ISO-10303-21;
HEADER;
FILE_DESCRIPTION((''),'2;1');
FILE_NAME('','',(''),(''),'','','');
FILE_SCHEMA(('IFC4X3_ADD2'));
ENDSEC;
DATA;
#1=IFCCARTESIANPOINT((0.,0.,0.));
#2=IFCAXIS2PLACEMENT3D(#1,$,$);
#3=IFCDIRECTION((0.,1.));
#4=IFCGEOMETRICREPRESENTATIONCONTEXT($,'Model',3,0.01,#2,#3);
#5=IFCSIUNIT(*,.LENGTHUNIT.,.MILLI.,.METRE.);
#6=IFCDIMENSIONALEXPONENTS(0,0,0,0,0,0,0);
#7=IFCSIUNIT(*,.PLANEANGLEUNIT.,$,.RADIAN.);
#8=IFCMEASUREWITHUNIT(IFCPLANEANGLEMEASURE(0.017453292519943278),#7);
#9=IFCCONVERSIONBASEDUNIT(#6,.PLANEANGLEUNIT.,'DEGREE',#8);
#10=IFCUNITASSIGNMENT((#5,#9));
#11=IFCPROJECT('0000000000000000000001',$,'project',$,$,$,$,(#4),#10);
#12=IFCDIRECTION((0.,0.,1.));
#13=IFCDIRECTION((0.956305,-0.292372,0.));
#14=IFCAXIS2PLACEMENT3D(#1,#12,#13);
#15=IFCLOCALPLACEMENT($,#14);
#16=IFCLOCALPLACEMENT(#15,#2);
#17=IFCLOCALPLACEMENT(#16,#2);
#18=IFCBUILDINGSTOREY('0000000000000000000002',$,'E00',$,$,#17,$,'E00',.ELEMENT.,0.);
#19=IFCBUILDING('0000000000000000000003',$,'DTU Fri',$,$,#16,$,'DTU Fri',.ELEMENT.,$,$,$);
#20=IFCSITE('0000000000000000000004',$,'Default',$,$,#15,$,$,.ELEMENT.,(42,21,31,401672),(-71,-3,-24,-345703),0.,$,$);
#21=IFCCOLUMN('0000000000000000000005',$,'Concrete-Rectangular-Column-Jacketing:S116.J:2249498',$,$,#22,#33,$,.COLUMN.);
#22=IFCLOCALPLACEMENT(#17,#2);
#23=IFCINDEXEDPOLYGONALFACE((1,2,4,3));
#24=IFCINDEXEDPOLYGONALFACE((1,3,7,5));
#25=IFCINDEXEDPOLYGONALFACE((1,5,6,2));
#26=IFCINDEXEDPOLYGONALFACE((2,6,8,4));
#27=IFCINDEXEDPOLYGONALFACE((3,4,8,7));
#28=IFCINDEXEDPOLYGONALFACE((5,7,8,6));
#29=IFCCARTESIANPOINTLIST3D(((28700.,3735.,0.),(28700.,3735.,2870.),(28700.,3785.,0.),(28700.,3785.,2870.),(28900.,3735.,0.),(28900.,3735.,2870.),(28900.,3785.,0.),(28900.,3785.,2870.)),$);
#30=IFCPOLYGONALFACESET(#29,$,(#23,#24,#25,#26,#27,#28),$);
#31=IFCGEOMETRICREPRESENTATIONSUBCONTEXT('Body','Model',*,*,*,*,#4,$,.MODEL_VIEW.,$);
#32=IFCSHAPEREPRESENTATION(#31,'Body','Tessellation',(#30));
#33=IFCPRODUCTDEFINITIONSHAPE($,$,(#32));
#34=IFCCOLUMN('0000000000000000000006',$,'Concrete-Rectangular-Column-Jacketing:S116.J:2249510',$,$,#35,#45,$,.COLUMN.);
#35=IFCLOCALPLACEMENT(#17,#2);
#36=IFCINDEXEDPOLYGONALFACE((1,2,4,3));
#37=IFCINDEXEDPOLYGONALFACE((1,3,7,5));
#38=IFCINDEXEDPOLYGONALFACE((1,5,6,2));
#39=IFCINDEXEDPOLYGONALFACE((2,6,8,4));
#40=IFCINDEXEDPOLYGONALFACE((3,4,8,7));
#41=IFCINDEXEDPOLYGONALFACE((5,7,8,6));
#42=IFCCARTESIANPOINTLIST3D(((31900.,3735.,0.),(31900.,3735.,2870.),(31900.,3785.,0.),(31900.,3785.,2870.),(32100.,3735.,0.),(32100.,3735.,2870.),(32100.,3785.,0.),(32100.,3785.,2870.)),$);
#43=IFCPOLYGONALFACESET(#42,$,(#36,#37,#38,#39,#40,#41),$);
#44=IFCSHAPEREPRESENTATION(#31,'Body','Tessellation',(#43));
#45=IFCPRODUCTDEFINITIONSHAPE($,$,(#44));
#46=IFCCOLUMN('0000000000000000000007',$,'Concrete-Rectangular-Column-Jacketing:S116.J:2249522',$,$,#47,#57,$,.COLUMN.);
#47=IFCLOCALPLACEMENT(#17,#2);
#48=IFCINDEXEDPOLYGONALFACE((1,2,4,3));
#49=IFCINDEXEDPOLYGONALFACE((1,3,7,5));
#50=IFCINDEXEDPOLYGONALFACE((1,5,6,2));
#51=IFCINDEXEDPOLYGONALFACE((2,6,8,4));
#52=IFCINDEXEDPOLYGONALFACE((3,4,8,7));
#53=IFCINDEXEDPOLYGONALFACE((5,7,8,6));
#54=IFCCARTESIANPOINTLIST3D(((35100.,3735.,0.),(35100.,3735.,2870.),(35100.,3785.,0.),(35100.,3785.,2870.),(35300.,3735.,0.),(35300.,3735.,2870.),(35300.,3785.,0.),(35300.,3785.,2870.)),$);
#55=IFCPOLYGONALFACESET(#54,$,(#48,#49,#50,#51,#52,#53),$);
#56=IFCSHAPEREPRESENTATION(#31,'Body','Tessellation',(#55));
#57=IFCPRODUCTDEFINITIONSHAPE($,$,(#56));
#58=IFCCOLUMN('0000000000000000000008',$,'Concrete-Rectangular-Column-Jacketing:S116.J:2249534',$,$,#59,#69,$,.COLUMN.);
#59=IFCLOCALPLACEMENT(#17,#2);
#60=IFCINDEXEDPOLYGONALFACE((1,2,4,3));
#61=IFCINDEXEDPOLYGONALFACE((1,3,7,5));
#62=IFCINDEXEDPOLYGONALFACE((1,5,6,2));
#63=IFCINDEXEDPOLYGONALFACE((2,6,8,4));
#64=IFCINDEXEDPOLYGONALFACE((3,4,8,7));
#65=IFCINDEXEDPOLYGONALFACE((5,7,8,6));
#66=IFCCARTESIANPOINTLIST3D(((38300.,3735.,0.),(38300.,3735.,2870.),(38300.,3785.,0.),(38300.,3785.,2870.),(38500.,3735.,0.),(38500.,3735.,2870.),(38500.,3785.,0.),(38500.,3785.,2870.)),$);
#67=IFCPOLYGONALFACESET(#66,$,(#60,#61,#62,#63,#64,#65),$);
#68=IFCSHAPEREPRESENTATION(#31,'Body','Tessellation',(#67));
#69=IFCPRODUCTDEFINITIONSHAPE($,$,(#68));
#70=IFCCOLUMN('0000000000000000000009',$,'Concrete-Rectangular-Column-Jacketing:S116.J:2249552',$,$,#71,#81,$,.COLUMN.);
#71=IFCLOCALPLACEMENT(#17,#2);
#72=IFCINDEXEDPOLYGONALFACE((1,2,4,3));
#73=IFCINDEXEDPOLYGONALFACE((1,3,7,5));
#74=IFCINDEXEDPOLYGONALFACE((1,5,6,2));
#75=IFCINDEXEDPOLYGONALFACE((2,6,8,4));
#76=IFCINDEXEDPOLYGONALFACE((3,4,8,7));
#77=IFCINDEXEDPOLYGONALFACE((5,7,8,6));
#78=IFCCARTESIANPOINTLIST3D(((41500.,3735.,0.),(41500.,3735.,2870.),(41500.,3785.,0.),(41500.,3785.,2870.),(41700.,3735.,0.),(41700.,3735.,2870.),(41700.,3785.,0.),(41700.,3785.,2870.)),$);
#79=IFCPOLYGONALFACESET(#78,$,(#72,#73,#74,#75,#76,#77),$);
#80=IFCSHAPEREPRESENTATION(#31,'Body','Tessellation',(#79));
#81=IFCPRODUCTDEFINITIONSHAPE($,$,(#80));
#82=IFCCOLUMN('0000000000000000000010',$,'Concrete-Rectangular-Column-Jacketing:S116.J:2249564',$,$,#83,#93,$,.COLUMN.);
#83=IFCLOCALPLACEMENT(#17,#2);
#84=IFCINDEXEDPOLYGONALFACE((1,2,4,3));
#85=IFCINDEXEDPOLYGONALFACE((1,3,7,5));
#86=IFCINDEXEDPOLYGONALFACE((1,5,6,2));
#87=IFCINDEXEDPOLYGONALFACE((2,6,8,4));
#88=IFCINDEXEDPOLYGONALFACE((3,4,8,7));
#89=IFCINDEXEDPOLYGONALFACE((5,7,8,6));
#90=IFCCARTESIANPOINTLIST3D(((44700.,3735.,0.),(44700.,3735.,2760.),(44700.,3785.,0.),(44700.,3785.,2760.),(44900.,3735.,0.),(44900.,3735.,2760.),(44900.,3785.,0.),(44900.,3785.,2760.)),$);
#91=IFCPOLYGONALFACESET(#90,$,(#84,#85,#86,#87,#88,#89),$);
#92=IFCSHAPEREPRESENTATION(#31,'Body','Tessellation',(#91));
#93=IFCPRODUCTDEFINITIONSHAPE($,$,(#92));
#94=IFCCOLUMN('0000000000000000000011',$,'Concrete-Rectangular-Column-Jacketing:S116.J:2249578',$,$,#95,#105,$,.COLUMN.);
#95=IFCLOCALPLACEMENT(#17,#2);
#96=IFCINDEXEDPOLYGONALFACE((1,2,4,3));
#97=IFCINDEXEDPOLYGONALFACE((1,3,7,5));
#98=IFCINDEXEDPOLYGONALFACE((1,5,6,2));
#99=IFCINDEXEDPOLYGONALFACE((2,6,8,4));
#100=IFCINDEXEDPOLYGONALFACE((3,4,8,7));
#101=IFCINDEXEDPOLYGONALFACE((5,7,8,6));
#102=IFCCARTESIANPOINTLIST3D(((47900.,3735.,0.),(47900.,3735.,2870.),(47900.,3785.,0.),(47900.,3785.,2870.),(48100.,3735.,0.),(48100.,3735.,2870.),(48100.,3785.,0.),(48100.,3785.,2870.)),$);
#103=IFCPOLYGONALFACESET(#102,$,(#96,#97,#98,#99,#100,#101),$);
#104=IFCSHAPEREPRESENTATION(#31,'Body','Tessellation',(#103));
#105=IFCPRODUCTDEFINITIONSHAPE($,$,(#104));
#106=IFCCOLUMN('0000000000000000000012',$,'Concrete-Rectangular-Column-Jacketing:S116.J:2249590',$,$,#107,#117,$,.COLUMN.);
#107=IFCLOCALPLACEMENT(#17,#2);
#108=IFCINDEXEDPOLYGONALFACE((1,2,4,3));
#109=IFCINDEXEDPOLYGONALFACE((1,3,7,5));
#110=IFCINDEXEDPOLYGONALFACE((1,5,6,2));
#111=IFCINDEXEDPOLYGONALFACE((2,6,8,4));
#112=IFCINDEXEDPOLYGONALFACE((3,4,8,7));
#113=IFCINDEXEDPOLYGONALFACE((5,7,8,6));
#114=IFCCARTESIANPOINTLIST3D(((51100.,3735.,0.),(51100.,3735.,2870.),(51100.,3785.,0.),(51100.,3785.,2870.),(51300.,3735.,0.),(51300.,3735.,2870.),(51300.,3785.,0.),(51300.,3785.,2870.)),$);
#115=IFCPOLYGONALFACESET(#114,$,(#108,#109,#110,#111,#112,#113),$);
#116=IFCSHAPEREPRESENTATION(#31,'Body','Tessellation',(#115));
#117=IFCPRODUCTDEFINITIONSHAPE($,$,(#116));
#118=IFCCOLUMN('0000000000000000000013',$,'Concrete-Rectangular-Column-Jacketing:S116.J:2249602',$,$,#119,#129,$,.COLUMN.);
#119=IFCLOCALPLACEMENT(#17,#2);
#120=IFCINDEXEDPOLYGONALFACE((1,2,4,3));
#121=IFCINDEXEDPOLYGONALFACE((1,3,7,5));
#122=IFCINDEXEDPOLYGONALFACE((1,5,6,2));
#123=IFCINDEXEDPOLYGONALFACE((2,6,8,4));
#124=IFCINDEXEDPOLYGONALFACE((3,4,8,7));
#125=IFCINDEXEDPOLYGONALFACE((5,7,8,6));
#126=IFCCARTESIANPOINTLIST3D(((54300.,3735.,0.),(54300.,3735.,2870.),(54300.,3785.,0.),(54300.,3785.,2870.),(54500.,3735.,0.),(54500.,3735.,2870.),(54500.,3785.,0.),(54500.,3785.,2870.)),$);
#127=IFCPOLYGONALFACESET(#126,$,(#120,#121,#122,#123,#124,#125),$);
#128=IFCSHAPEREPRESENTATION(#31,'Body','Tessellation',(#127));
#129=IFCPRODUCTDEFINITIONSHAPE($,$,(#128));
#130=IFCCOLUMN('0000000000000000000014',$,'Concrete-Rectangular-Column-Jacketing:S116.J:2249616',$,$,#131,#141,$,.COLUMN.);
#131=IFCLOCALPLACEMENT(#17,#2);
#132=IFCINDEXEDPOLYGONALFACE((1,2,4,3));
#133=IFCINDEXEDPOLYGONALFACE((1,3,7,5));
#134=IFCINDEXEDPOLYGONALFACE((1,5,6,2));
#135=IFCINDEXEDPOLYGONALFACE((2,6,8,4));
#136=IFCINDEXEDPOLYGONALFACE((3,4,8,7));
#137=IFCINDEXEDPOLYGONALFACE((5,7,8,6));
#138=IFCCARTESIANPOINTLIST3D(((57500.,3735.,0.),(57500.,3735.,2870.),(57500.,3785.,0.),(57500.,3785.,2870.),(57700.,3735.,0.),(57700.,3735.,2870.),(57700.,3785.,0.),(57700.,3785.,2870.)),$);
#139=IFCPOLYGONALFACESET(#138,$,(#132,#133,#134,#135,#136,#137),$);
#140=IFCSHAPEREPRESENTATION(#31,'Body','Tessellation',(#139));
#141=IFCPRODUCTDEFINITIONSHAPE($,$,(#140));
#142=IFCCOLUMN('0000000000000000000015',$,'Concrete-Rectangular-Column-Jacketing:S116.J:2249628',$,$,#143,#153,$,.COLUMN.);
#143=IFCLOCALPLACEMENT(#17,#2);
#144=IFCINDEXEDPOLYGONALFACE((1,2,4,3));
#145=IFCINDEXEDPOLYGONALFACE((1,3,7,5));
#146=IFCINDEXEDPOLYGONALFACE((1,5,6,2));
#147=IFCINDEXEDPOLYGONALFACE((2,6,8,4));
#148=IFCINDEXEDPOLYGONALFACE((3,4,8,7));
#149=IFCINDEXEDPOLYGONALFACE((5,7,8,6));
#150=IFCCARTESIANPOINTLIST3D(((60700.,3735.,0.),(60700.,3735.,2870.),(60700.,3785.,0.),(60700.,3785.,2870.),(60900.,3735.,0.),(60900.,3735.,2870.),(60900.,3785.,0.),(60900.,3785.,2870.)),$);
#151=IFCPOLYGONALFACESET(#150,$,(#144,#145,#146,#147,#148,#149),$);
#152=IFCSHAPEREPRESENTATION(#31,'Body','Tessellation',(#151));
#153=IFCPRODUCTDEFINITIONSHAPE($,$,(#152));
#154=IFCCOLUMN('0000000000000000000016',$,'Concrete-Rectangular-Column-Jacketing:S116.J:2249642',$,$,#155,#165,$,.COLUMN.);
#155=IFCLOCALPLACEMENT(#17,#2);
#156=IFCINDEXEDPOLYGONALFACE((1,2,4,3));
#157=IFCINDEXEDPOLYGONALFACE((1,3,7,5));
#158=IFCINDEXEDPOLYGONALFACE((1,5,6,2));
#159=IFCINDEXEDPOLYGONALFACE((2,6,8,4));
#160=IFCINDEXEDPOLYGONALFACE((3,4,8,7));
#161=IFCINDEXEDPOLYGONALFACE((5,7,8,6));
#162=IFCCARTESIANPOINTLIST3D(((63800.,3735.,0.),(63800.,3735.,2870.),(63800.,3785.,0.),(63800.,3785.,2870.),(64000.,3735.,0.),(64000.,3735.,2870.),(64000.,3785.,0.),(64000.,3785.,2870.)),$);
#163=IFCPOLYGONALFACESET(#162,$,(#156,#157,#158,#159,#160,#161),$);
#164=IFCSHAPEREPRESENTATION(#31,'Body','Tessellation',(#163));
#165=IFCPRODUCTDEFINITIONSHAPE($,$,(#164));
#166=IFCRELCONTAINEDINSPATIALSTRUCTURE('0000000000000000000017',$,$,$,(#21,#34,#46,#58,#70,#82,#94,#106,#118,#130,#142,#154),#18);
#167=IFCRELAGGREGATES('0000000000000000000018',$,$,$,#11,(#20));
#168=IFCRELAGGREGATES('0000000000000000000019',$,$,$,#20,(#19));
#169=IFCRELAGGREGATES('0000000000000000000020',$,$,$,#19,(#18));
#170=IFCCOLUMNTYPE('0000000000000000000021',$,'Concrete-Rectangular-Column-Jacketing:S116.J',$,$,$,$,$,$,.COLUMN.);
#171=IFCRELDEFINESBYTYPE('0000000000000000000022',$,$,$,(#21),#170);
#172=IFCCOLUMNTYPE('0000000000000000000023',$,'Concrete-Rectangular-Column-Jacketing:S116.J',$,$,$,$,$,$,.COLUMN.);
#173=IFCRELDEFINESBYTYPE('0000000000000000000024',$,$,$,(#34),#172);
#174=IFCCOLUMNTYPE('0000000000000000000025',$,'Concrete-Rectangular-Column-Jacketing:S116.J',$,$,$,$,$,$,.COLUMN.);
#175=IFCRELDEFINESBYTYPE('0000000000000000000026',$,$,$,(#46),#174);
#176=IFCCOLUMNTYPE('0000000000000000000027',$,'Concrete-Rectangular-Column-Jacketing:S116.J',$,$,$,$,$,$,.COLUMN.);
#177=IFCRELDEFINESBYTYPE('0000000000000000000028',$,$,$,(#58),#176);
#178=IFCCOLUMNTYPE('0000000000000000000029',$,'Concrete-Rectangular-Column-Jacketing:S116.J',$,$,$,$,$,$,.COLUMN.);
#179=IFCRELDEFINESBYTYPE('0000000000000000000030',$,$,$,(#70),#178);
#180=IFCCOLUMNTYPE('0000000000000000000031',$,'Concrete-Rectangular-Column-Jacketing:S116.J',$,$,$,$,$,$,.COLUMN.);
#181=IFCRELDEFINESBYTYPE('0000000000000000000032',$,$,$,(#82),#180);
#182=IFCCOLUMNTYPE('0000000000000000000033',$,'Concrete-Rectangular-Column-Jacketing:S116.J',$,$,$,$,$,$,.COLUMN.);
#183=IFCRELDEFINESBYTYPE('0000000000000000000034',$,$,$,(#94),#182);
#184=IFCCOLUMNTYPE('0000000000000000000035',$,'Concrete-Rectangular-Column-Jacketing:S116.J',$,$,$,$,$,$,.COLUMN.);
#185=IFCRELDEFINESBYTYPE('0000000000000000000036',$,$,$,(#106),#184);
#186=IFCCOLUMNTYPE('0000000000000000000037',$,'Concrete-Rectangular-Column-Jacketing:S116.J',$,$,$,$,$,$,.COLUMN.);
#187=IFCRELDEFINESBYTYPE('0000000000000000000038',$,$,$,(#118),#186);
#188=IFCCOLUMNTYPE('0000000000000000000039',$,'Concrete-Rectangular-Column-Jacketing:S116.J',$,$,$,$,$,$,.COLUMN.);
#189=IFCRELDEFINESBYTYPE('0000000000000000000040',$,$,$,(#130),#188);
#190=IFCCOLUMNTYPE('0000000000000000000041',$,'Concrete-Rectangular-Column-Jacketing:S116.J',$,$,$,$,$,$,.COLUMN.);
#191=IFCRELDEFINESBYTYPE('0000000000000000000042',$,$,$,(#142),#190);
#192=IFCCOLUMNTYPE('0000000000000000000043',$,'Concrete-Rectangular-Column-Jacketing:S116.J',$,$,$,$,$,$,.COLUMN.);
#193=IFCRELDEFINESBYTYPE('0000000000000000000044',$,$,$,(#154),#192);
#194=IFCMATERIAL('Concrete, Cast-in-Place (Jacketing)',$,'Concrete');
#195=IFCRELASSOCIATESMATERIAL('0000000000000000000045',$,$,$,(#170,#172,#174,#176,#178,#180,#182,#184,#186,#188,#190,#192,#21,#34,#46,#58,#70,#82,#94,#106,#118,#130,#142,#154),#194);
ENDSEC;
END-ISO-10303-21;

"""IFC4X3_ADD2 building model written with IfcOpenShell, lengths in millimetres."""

from ifc_helpers import new_model, entity, si_unit, converted_unit, direction, frame, frame_2d, origin, place, context, subcontext, project, spatial, rectangle, extrude, source, transform, mapped, material, material_profile, profile_set, profile_usage, type_object, type_shapes, element, save


model = new_model("IFC4X3_ADD2")

# Units and contexts
model_context = context("Model", 3, precision=0.01, world=origin(), true_north=direction((0.0, 1.0)))
body_context = subcontext(model_context, "Body", "Model", "MODEL_VIEW")
ifc_project = project(units=[si_unit("LENGTHUNIT", "METRE", prefix="MILLI"), converted_unit("PLANEANGLEUNIT", "DEGREE", entity("IfcPlaneAngleMeasure", 0.017453292519943278), si_unit("PLANEANGLEUNIT", "RADIAN"), dimensions=[0, 0, 0, 0, 0, 0, 0])], contexts=[model_context])

# Site, building, storey
site_placement = place(None, frame((0.0, 0.0, 0.0), z_axis=(0.0, 0.0, 1.0), x_axis=(0.956305, -0.292372, 0.0)))
site = spatial("IfcSite", under=ifc_project, at=site_placement, Name="Default", CompositionType="ELEMENT", RefLatitude=(42, 21, 31, 401672), RefLongitude=(-71, -3, -24, -345703), RefElevation=0.0)
building_placement = place(site_placement, origin())
building = spatial("IfcBuilding", under=site, at=building_placement, Name="DTU Fri", LongName="DTU Fri", CompositionType="ELEMENT")
storey_placement = place(building_placement, origin())
storey = spatial("IfcBuildingStorey", under=building, at=storey_placement, Name="E00", LongName="E00", CompositionType="ELEMENT", Elevation=0.0)

# Columns
ifc_material_1 = material(Name="Concrete, Cast-in-Place (Jacketing)", Category="Concrete")
ifc_material_profile = material_profile(ifc_material_1, rectangle(XDim=50.0, YDim=200.0, at=frame_2d((0.0, 0.0), x_axis=(1.0, 0.0))), Name="S116.J")
ifc_profile_set = profile_set([ifc_material_profile], Name="S116.J")
ifc_profile_usage = profile_usage(ifc_profile_set)
column_type_1 = type_object("IfcColumnType", Name="Concrete-Rectangular-Column-Jacketing:S116.J", PredefinedType="COLUMN", material=ifc_profile_set)
shared_shape_1 = source(origin(), body_context, "Body", "SweptSolid", [
    extrude(rectangle(XDim=50.0, YDim=200.0, at=frame_2d((0.0, 0.0), x_axis=(1.0, 0.0))), frame((28800.0, 3760.0, 0.0), z_axis=(0.0, 0.0, 1.0), x_axis=(0.0, -1.0, 0.0)), (0.0, 0.0, 1.0), 2870.0),
])
type_shapes(column_type_1, [shared_shape_1])
column_1_placement = place(storey_placement, origin())
element("IfcColumn", 1, at=column_1_placement, inside=storey, type_object=column_type_1, material=ifc_profile_usage, Name="Concrete-Rectangular-Column-Jacketing:S116.J:2249498", PredefinedType="COLUMN", context=body_context, shape_type="MappedRepresentation", body=[
    mapped(shared_shape_1, transform((0.0, 0.0, 0.0), scale=1.0)),
])
column_type_2 = type_object("IfcColumnType", Name="Concrete-Rectangular-Column-Jacketing:S116.J", PredefinedType="COLUMN", material=ifc_profile_set)
shared_shape_2 = source(origin(), body_context, "Body", "SweptSolid", [
    extrude(rectangle(XDim=50.0, YDim=200.0, at=frame_2d((0.0, 0.0), x_axis=(1.0, 0.0))), frame((32000.0, 3760.0, 0.0), z_axis=(0.0, 0.0, 1.0), x_axis=(0.0, -1.0, 0.0)), (0.0, 0.0, 1.0), 2870.0),
])
type_shapes(column_type_2, [shared_shape_2])
column_2_placement = place(storey_placement, origin())
element("IfcColumn", 2, at=column_2_placement, inside=storey, type_object=column_type_2, material=ifc_profile_usage, Name="Concrete-Rectangular-Column-Jacketing:S116.J:2249510", PredefinedType="COLUMN", context=body_context, shape_type="MappedRepresentation", body=[
    mapped(shared_shape_2, transform((0.0, 0.0, 0.0), scale=1.0)),
])
column_type_3 = type_object("IfcColumnType", Name="Concrete-Rectangular-Column-Jacketing:S116.J", PredefinedType="COLUMN", material=ifc_profile_set)
shared_shape_3 = source(origin(), body_context, "Body", "SweptSolid", [
    extrude(rectangle(XDim=50.0, YDim=200.0, at=frame_2d((0.0, 0.0), x_axis=(1.0, 0.0))), frame((35200.0, 3760.0, 0.0), z_axis=(0.0, 0.0, 1.0), x_axis=(0.0, -1.0, 0.0)), (0.0, 0.0, 1.0), 2870.0),
])
type_shapes(column_type_3, [shared_shape_3])
column_3_placement = place(storey_placement, origin())
element("IfcColumn", 3, at=column_3_placement, inside=storey, type_object=column_type_3, material=ifc_profile_usage, Name="Concrete-Rectangular-Column-Jacketing:S116.J:2249522", PredefinedType="COLUMN", context=body_context, shape_type="MappedRepresentation", body=[
    mapped(shared_shape_3, transform((0.0, 0.0, 0.0), scale=1.0)),
])
column_type_4 = type_object("IfcColumnType", Name="Concrete-Rectangular-Column-Jacketing:S116.J", PredefinedType="COLUMN", material=ifc_profile_set)
shared_shape_4 = source(origin(), body_context, "Body", "SweptSolid", [
    extrude(rectangle(XDim=50.0, YDim=200.0, at=frame_2d((0.0, 0.0), x_axis=(1.0, 0.0))), frame((38400.0, 3760.0, 0.0), z_axis=(0.0, 0.0, 1.0), x_axis=(0.0, -1.0, 0.0)), (0.0, 0.0, 1.0), 2870.0),
])
type_shapes(column_type_4, [shared_shape_4])
column_4_placement = place(storey_placement, origin())
element("IfcColumn", 4, at=column_4_placement, inside=storey, type_object=column_type_4, material=ifc_profile_usage, Name="Concrete-Rectangular-Column-Jacketing:S116.J:2249534", PredefinedType="COLUMN", context=body_context, shape_type="MappedRepresentation", body=[
    mapped(shared_shape_4, transform((0.0, 0.0, 0.0), scale=1.0)),
])
column_type_5 = type_object("IfcColumnType", Name="Concrete-Rectangular-Column-Jacketing:S116.J", PredefinedType="COLUMN", material=ifc_profile_set)
shared_shape_5 = source(origin(), body_context, "Body", "SweptSolid", [
    extrude(rectangle(XDim=50.0, YDim=200.0, at=frame_2d((0.0, 0.0), x_axis=(1.0, 0.0))), frame((41600.0, 3760.0, 0.0), z_axis=(0.0, 0.0, 1.0), x_axis=(0.0, -1.0, 0.0)), (0.0, 0.0, 1.0), 2870.0),
])
type_shapes(column_type_5, [shared_shape_5])
column_5_placement = place(storey_placement, origin())
element("IfcColumn", 5, at=column_5_placement, inside=storey, type_object=column_type_5, material=ifc_profile_usage, Name="Concrete-Rectangular-Column-Jacketing:S116.J:2249552", PredefinedType="COLUMN", context=body_context, shape_type="MappedRepresentation", body=[
    mapped(shared_shape_5, transform((0.0, 0.0, 0.0), scale=1.0)),
])
column_type_6 = type_object("IfcColumnType", Name="Concrete-Rectangular-Column-Jacketing:S116.J", PredefinedType="COLUMN", material=ifc_profile_set)
shared_shape_6 = source(origin(), body_context, "Body", "SweptSolid", [
    extrude(rectangle(XDim=50.0, YDim=200.0, at=frame_2d((0.0, 0.0), x_axis=(1.0, 0.0))), frame((44800.0, 3760.0, 0.0), z_axis=(0.0, 0.0, 1.0), x_axis=(0.0, -1.0, 0.0)), (0.0, 0.0, 1.0), 2760.0),
])
type_shapes(column_type_6, [shared_shape_6])
column_6_placement = place(storey_placement, origin())
element("IfcColumn", 6, at=column_6_placement, inside=storey, type_object=column_type_6, material=ifc_profile_usage, Name="Concrete-Rectangular-Column-Jacketing:S116.J:2249564", PredefinedType="COLUMN", context=body_context, shape_type="MappedRepresentation", body=[
    mapped(shared_shape_6, transform((0.0, 0.0, 0.0), scale=1.0)),
])
column_type_7 = type_object("IfcColumnType", Name="Concrete-Rectangular-Column-Jacketing:S116.J", PredefinedType="COLUMN", material=ifc_profile_set)
shared_shape_7 = source(origin(), body_context, "Body", "SweptSolid", [
    extrude(rectangle(XDim=50.0, YDim=200.0, at=frame_2d((0.0, 0.0), x_axis=(1.0, 0.0))), frame((48000.0, 3760.0, 0.0), z_axis=(0.0, 0.0, 1.0), x_axis=(0.0, -1.0, 0.0)), (0.0, 0.0, 1.0), 2870.0),
])
type_shapes(column_type_7, [shared_shape_7])
column_7_placement = place(storey_placement, origin())
element("IfcColumn", 7, at=column_7_placement, inside=storey, type_object=column_type_7, material=ifc_profile_usage, Name="Concrete-Rectangular-Column-Jacketing:S116.J:2249578", PredefinedType="COLUMN", context=body_context, shape_type="MappedRepresentation", body=[
    mapped(shared_shape_7, transform((0.0, 0.0, 0.0), scale=1.0)),
])
column_type_8 = type_object("IfcColumnType", Name="Concrete-Rectangular-Column-Jacketing:S116.J", PredefinedType="COLUMN", material=ifc_profile_set)
shared_shape_8 = source(origin(), body_context, "Body", "SweptSolid", [
    extrude(rectangle(XDim=50.0, YDim=200.0, at=frame_2d((0.0, 0.0), x_axis=(1.0, 0.0))), frame((51200.0, 3760.0, 0.0), z_axis=(0.0, 0.0, 1.0), x_axis=(0.0, -1.0, 0.0)), (0.0, 0.0, 1.0), 2870.0),
])
type_shapes(column_type_8, [shared_shape_8])
column_8_placement = place(storey_placement, origin())
element("IfcColumn", 8, at=column_8_placement, inside=storey, type_object=column_type_8, material=ifc_profile_usage, Name="Concrete-Rectangular-Column-Jacketing:S116.J:2249590", PredefinedType="COLUMN", context=body_context, shape_type="MappedRepresentation", body=[
    mapped(shared_shape_8, transform((0.0, 0.0, 0.0), scale=1.0)),
])
column_type_9 = type_object("IfcColumnType", Name="Concrete-Rectangular-Column-Jacketing:S116.J", PredefinedType="COLUMN", material=ifc_profile_set)
shared_shape_9 = source(origin(), body_context, "Body", "SweptSolid", [
    extrude(rectangle(XDim=50.0, YDim=200.0, at=frame_2d((0.0, 0.0), x_axis=(1.0, 0.0))), frame((54400.0, 3760.0, 0.0), z_axis=(0.0, 0.0, 1.0), x_axis=(0.0, -1.0, 0.0)), (0.0, 0.0, 1.0), 2870.0),
])
type_shapes(column_type_9, [shared_shape_9])
column_9_placement = place(storey_placement, origin())
element("IfcColumn", 9, at=column_9_placement, inside=storey, type_object=column_type_9, material=ifc_profile_usage, Name="Concrete-Rectangular-Column-Jacketing:S116.J:2249602", PredefinedType="COLUMN", context=body_context, shape_type="MappedRepresentation", body=[
    mapped(shared_shape_9, transform((0.0, 0.0, 0.0), scale=1.0)),
])
column_type_10 = type_object("IfcColumnType", Name="Concrete-Rectangular-Column-Jacketing:S116.J", PredefinedType="COLUMN", material=ifc_profile_set)
shared_shape_10 = source(origin(), body_context, "Body", "SweptSolid", [
    extrude(rectangle(XDim=50.0, YDim=200.0, at=frame_2d((0.0, 0.0), x_axis=(1.0, 0.0))), frame((57600.0, 3760.0, 0.0), z_axis=(0.0, 0.0, 1.0), x_axis=(0.0, -1.0, 0.0)), (0.0, 0.0, 1.0), 2870.0),
])
type_shapes(column_type_10, [shared_shape_10])
column_10_placement = place(storey_placement, origin())
element("IfcColumn", 10, at=column_10_placement, inside=storey, type_object=column_type_10, material=ifc_profile_usage, Name="Concrete-Rectangular-Column-Jacketing:S116.J:2249616", PredefinedType="COLUMN", context=body_context, shape_type="MappedRepresentation", body=[
    mapped(shared_shape_10, transform((0.0, 0.0, 0.0), scale=1.0)),
])
column_type_11 = type_object("IfcColumnType", Name="Concrete-Rectangular-Column-Jacketing:S116.J", PredefinedType="COLUMN", material=ifc_profile_set)
shared_shape_11 = source(origin(), body_context, "Body", "SweptSolid", [
    extrude(rectangle(XDim=50.0, YDim=200.0, at=frame_2d((0.0, 0.0), x_axis=(1.0, 0.0))), frame((60800.0, 3760.0, 0.0), z_axis=(0.0, 0.0, 1.0), x_axis=(0.0, -1.0, 0.0)), (0.0, 0.0, 1.0), 2870.0),
])
type_shapes(column_type_11, [shared_shape_11])
column_11_placement = place(storey_placement, origin())
element("IfcColumn", 11, at=column_11_placement, inside=storey, type_object=column_type_11, material=ifc_profile_usage, Name="Concrete-Rectangular-Column-Jacketing:S116.J:2249628", PredefinedType="COLUMN", context=body_context, shape_type="MappedRepresentation", body=[
    mapped(shared_shape_11, transform((0.0, 0.0, 0.0), scale=1.0)),
])
column_type_12 = type_object("IfcColumnType", Name="Concrete-Rectangular-Column-Jacketing:S116.J", PredefinedType="COLUMN", material=ifc_profile_set)
shared_shape_12 = source(origin(), body_context, "Body", "SweptSolid", [
    extrude(rectangle(XDim=50.0, YDim=200.0, at=frame_2d((0.0, 0.0), x_axis=(1.0, 0.0))), frame((63900.0, 3760.0, 0.0), z_axis=(0.0, 0.0, 1.0), x_axis=(0.0, -1.0, 0.0)), (0.0, 0.0, 1.0), 2870.0),
])
type_shapes(column_type_12, [shared_shape_12])
column_12_placement = place(storey_placement, origin())
element("IfcColumn", 12, at=column_12_placement, inside=storey, type_object=column_type_12, material=ifc_profile_usage, Name="Concrete-Rectangular-Column-Jacketing:S116.J:2249642", PredefinedType="COLUMN", context=body_context, shape_type="MappedRepresentation", body=[
    mapped(shared_shape_12, transform((0.0, 0.0, 0.0), scale=1.0)),
])

save(model, "model.ifc")
